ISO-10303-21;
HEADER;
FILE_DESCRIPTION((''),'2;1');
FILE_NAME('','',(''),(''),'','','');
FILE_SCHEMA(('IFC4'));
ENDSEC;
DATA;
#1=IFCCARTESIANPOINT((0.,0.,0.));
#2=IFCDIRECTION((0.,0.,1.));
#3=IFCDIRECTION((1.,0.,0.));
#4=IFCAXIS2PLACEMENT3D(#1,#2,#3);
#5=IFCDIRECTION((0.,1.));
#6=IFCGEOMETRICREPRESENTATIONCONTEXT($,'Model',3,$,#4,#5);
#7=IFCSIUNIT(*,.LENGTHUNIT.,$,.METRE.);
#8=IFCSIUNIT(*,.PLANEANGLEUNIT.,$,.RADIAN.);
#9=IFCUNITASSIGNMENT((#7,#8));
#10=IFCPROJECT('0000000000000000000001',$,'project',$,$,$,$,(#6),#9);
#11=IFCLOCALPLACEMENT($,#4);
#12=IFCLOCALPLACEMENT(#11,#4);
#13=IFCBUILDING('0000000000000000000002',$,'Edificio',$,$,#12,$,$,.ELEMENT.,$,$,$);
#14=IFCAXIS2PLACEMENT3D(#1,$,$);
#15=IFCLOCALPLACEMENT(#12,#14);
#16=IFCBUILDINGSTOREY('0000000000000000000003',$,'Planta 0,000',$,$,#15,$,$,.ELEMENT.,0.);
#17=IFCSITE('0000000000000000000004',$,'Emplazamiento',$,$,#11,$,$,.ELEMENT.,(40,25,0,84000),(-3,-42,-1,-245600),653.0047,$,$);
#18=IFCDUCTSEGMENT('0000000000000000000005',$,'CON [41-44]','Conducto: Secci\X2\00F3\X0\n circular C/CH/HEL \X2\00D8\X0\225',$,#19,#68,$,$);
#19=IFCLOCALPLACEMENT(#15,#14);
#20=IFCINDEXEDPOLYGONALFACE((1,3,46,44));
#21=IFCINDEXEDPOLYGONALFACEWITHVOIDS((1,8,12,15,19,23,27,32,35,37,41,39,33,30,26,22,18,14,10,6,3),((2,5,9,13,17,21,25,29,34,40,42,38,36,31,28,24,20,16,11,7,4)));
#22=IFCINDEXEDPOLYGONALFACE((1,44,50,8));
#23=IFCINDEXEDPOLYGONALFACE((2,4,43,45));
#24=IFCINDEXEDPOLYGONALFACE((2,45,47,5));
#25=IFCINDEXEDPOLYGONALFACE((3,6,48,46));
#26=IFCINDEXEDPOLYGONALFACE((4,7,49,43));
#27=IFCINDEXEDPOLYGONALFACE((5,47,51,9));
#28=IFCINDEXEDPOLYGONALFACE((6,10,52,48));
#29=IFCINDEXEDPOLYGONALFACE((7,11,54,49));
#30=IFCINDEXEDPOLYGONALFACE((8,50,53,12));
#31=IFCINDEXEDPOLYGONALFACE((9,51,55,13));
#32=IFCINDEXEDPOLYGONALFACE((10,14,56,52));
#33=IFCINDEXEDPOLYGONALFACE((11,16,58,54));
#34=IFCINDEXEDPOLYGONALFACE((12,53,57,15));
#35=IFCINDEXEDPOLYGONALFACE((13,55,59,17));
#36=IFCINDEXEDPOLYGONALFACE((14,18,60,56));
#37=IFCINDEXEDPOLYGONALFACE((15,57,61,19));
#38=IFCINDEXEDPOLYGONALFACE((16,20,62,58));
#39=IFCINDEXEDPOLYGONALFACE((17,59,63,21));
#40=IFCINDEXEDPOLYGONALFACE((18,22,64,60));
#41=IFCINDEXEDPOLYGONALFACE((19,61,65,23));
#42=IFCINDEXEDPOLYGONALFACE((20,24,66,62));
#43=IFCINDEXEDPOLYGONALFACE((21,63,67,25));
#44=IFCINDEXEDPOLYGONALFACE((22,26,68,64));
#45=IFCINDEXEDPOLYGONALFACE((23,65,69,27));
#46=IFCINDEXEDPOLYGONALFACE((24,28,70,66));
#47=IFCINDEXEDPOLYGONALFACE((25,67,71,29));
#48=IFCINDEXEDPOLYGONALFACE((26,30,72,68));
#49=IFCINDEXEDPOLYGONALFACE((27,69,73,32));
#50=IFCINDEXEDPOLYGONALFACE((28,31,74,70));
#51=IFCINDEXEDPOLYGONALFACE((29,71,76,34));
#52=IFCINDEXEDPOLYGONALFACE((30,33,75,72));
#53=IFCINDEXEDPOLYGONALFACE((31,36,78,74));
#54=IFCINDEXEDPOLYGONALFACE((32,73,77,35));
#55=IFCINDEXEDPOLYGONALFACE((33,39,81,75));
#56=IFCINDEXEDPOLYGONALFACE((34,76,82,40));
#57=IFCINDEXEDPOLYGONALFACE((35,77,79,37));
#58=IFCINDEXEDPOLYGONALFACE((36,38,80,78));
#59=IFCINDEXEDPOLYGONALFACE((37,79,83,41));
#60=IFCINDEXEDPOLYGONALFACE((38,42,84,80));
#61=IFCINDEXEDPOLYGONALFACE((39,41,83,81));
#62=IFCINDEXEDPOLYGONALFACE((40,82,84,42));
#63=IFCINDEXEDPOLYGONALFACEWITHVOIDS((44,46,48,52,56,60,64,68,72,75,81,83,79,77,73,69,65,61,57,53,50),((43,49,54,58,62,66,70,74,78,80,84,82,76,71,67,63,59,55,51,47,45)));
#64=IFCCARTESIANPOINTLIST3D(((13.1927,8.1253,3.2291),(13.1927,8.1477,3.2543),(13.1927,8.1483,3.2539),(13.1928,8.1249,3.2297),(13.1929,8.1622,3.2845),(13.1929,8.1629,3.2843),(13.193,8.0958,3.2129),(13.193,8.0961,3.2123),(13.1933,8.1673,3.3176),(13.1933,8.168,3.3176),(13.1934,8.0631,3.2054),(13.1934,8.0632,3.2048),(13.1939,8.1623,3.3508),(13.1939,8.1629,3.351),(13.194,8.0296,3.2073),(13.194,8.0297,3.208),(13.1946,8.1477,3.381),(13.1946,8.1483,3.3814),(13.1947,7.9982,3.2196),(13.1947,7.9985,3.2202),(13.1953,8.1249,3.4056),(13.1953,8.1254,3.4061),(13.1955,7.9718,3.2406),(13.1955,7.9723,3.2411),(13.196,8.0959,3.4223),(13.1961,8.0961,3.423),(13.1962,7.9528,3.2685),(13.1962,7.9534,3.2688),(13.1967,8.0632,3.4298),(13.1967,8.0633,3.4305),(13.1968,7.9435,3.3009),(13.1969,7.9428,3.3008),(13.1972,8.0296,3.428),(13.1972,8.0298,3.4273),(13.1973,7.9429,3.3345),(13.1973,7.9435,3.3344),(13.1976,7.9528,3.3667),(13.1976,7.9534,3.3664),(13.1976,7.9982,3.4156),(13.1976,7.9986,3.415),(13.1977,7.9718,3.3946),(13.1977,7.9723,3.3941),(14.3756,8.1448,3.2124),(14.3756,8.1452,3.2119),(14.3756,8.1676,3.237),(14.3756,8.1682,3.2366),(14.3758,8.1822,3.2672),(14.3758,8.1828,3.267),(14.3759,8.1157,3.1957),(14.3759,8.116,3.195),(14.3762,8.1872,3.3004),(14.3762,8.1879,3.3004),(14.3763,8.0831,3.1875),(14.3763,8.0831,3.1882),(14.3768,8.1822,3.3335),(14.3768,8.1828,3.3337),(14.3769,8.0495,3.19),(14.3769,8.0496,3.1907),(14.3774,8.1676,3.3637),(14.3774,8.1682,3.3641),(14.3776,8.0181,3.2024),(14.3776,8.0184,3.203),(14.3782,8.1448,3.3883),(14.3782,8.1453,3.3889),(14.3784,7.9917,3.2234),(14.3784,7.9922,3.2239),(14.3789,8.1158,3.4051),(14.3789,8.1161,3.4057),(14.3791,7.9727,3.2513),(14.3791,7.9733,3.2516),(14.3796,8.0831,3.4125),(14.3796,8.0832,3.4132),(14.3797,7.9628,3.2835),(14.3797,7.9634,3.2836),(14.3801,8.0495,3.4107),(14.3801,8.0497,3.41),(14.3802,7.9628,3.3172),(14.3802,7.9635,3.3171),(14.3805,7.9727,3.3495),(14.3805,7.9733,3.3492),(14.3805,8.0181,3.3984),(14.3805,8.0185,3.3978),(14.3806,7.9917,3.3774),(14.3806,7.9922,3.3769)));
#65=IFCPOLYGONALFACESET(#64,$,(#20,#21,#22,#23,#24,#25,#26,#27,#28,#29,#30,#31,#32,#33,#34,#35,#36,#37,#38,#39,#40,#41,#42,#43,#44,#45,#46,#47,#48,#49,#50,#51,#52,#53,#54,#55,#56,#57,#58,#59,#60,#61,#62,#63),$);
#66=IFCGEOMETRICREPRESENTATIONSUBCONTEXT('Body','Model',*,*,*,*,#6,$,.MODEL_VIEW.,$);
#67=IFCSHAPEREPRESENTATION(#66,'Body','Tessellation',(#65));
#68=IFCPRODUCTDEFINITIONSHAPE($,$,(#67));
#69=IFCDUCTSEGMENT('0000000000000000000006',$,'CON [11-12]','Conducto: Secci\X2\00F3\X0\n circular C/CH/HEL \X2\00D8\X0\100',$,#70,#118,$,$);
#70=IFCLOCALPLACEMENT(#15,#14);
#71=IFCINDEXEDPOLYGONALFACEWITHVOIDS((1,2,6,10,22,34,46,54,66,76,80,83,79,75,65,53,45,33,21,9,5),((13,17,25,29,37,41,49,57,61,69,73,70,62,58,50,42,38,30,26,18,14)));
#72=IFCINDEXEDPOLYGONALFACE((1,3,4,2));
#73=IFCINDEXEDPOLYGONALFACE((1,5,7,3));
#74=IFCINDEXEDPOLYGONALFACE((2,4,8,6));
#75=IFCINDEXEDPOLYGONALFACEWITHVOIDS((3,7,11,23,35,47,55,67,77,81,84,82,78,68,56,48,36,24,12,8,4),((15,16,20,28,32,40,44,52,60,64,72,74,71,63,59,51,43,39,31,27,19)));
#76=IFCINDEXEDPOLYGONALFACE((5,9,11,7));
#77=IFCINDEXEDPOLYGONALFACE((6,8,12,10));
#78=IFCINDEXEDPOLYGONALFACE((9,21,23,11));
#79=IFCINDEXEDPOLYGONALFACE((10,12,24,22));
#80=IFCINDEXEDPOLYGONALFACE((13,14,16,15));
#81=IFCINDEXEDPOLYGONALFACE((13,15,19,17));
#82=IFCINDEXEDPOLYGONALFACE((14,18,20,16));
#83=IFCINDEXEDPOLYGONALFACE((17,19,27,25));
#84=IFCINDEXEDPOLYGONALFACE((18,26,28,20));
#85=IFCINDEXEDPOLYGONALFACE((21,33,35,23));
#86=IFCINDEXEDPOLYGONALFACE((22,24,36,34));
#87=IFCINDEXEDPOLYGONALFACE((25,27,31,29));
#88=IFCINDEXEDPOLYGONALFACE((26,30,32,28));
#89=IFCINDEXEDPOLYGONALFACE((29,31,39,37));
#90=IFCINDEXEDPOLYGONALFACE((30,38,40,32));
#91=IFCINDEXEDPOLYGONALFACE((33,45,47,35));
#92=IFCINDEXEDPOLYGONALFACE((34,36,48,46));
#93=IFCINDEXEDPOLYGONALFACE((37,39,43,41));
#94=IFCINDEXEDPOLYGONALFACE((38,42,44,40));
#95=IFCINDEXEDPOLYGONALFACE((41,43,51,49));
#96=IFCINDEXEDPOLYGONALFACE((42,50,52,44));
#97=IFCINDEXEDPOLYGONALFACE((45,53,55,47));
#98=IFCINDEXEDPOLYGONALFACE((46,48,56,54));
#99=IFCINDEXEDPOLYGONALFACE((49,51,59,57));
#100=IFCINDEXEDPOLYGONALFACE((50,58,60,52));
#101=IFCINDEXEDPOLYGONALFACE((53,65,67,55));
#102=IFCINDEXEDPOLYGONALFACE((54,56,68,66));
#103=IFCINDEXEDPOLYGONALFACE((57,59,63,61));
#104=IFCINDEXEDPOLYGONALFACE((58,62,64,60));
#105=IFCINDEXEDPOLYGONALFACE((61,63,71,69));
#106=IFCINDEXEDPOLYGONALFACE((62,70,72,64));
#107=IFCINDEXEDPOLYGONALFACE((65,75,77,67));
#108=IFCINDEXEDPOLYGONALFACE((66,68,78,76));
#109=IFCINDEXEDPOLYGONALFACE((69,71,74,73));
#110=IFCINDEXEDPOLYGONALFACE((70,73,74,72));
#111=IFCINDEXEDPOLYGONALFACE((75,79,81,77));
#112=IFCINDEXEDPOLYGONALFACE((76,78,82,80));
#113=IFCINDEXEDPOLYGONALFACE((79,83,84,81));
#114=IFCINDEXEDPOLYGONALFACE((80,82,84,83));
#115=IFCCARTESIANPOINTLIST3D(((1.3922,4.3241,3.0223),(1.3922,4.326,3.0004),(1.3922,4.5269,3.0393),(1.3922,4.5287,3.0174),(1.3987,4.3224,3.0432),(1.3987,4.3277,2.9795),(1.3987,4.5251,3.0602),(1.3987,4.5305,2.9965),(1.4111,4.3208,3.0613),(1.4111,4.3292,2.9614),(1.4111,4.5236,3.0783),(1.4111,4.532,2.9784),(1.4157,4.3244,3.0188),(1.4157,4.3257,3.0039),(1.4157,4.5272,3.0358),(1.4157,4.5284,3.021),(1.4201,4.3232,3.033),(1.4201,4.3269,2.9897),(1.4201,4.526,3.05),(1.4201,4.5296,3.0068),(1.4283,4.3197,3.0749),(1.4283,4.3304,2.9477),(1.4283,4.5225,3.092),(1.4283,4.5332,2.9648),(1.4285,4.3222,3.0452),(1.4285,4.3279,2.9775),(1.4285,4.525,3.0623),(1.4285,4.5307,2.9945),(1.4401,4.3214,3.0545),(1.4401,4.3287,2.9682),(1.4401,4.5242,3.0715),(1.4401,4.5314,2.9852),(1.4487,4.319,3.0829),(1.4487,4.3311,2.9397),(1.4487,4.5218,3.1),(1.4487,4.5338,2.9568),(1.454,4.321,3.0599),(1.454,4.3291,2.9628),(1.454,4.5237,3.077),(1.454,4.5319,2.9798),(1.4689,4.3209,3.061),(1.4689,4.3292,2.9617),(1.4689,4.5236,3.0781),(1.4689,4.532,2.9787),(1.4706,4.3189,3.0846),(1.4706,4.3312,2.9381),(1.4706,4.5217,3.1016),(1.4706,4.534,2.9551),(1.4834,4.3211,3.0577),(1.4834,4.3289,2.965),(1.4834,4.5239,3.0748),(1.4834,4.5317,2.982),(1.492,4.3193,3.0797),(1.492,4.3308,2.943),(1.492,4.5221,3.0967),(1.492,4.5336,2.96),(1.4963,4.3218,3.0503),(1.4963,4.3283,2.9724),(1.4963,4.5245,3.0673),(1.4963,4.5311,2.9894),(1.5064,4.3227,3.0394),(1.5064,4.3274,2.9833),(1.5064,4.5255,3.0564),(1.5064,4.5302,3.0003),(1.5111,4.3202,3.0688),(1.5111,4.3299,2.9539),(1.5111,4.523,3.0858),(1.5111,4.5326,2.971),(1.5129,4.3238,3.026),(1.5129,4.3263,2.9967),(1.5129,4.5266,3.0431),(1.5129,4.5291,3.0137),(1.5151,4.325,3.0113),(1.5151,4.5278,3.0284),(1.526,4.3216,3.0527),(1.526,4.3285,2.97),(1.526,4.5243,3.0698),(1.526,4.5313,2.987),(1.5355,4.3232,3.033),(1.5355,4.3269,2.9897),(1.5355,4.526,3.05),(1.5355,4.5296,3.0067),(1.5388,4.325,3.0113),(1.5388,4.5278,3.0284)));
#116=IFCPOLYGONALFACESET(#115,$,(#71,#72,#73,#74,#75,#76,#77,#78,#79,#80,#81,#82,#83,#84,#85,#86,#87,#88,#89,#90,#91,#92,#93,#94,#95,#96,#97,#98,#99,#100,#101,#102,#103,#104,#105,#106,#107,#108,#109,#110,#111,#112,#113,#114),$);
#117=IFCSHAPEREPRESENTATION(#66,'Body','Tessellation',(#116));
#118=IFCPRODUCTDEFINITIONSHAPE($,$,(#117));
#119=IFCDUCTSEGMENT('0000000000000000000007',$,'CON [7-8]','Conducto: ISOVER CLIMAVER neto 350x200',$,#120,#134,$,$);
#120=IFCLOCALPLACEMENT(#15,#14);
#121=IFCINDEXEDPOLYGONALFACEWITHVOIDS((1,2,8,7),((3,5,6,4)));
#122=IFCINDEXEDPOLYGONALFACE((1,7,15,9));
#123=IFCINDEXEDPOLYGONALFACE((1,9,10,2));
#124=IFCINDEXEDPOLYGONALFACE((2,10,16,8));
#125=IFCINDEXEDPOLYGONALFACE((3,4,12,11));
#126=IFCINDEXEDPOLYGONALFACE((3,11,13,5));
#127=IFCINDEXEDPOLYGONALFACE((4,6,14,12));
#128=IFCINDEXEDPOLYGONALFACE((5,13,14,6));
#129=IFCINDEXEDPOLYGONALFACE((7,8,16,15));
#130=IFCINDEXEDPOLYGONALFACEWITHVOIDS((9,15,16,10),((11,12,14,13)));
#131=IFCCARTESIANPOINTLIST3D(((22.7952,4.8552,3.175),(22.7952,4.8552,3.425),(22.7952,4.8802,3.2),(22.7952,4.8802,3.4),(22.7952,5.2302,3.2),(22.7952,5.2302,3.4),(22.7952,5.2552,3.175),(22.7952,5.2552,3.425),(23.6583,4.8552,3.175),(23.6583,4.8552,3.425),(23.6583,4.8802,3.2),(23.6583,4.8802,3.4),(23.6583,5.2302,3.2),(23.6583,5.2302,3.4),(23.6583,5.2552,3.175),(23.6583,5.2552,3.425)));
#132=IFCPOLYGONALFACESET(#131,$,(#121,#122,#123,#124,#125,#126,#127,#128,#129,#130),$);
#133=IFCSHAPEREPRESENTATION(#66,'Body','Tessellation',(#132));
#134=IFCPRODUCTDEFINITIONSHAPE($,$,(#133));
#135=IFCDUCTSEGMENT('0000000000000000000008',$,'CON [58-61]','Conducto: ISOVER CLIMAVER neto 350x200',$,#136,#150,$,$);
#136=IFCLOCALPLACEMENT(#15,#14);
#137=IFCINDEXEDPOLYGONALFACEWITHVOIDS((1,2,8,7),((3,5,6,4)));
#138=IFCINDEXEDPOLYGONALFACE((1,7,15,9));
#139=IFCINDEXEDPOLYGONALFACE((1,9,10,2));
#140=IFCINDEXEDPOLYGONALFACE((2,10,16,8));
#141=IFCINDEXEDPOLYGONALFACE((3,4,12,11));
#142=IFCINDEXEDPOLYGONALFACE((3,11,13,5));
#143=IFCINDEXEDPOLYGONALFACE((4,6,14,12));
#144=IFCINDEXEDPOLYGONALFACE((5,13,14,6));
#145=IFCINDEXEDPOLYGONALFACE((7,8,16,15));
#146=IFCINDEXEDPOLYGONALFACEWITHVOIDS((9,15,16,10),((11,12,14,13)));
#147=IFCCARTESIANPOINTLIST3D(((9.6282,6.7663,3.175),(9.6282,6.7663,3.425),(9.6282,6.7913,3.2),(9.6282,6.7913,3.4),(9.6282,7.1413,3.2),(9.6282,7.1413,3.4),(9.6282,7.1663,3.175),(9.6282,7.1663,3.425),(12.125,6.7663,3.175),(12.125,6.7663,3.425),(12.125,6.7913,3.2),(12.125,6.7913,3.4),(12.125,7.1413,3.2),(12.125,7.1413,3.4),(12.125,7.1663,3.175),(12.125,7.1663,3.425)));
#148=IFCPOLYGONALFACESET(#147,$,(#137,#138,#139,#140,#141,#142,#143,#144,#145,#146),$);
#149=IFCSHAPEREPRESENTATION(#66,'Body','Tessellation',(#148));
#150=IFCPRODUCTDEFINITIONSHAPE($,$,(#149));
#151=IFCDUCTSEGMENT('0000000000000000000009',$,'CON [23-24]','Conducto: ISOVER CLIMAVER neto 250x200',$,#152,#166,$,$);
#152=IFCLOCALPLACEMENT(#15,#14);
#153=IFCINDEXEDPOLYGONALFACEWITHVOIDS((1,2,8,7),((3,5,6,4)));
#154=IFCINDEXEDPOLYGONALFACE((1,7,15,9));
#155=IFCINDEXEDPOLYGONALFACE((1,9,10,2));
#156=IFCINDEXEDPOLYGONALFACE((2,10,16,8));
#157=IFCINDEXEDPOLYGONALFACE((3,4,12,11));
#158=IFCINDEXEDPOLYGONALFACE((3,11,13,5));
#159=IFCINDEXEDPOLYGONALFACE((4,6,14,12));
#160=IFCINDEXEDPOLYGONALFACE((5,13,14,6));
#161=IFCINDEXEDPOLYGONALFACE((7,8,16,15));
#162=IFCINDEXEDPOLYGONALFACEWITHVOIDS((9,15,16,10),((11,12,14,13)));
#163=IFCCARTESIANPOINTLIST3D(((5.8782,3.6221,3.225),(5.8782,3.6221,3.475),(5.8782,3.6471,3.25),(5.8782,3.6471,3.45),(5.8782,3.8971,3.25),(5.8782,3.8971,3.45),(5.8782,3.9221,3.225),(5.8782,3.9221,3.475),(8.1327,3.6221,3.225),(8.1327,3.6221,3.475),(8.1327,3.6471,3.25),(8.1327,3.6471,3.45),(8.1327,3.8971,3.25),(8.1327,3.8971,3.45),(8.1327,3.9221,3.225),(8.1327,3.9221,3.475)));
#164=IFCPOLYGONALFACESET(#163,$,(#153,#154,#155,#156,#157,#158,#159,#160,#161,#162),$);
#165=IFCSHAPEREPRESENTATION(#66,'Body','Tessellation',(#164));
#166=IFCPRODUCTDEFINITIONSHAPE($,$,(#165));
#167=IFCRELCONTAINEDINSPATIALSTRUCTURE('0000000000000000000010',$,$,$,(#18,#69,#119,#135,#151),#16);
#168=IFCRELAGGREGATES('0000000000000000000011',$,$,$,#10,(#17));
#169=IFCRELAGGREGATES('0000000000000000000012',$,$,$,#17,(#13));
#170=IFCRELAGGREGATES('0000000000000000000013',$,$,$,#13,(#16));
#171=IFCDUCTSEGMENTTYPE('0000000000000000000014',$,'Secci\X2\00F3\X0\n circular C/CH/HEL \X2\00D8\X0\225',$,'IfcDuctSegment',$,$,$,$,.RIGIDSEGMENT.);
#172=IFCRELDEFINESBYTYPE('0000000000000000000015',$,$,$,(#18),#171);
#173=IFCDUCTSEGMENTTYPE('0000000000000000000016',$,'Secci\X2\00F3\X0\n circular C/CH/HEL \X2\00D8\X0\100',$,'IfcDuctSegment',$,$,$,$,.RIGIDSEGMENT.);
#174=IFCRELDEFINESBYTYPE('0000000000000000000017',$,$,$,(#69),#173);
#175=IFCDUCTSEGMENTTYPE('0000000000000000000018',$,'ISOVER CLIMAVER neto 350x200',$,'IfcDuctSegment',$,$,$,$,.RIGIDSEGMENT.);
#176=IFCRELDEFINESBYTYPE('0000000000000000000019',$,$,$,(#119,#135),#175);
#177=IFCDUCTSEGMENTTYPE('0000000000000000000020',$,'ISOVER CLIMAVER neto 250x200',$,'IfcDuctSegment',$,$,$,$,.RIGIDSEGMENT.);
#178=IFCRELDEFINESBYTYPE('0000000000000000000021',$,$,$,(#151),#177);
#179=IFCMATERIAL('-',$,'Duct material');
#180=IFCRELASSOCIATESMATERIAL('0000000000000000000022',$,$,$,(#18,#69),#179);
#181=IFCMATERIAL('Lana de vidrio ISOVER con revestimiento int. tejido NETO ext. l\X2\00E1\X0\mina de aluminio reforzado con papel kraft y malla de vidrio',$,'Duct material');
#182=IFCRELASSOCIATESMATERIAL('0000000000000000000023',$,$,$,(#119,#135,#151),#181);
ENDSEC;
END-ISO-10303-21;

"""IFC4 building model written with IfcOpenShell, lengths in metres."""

from ifc_helpers import new_model, si_unit, direction, frame, origin, origin_with_axes, origin_2d_with_axis, place, context, subcontext, project, spatial, hollow_rectangle, hollow_circle, extrude, material, type_object, element, save


model = new_model("IFC4")

# Units and contexts
model_context = context("Model", 3, world=origin_with_axes(), true_north=direction((0.0, 1.0)))
body_context = subcontext(model_context, "Body", "Model", "MODEL_VIEW")
ifc_project = project(units=[si_unit("LENGTHUNIT", "METRE"), si_unit("PLANEANGLEUNIT", "RADIAN")], contexts=[model_context])

# Site, building, storey
site_placement = place(None, origin_with_axes())
site = spatial("IfcSite", under=ifc_project, at=site_placement, Name="Emplazamiento", CompositionType="ELEMENT", RefLatitude=(40, 25, 0, 84000), RefLongitude=(-3, -42, -1, -245600), RefElevation=653.0047)
building_placement = place(site_placement, origin_with_axes())
building = spatial("IfcBuilding", under=site, at=building_placement, Name="Edificio", CompositionType="ELEMENT")
storey_placement = place(building_placement, origin())
storey = spatial("IfcBuildingStorey", under=building, at=storey_placement, Name="Planta 0,000", CompositionType="ELEMENT", Elevation=0.0)

# Shared definitions
ifc_material_1 = material(Name="-", Category="Duct material")

# Shared definitions
ifc_material_2 = material(Name="Lana de vidrio ISOVER con revestimiento int. tejido NETO ext. lámina de aluminio reforzado con papel kraft y malla de vidrio", Category="Duct material")

# Duct segments
duct_segment_type_1 = type_object("IfcDuctSegmentType", Name="Sección circular C/CH/HEL Ø225", ApplicableOccurrence="IfcDuctSegment", PredefinedType="RIGIDSEGMENT")
duct_segment_1_placement = place(storey_placement, origin_with_axes())
element("IfcDuctSegment", 1, at=duct_segment_1_placement, inside=storey, type_object=duct_segment_type_1, material=ifc_material_1, Name="CON [41-44]", Description="Conducto: Sección circular C/CH/HEL Ø225", context=body_context, shape_type="SweptSolid", body=[
    extrude(hollow_circle(Radius=0.1132, WallThickness=0.0007, at=origin_2d_with_axis()), frame((13.1952, 8.0548, 3.3176), z_axis=(0.999752, 0.016826, -0.014576), x_axis=(-0.016828, 0.999858, 0.0)), (0.0, 0.0, 1.0), 1.1832),
])
duct_segment_type_2 = type_object("IfcDuctSegmentType", Name="Sección circular C/CH/HEL Ø100", ApplicableOccurrence="IfcDuctSegment", PredefinedType="RIGIDSEGMENT")
duct_segment_2_placement = place(storey_placement, origin_with_axes())
element("IfcDuctSegment", 2, at=duct_segment_2_placement, inside=storey, type_object=duct_segment_type_2, material=ifc_material_1, Name="CON [11-12]", Description="Conducto: Sección circular C/CH/HEL Ø100", context=body_context, shape_type="SweptSolid", body=[
    extrude(hollow_circle(Radius=0.0737, WallThickness=0.0237, at=origin_2d_with_axis()), frame((1.4651, 4.5278, 3.0284), z_axis=(0.0, -0.99649, -0.083712), x_axis=(1.0, 0.0, 0.0)), (0.0, 0.0, 1.0), 0.2035),
])

# Duct segments
duct_segment_type_3 = type_object("IfcDuctSegmentType", Name="ISOVER CLIMAVER neto 350x200", ApplicableOccurrence="IfcDuctSegment", PredefinedType="RIGIDSEGMENT")
duct_segment_3_placement = place(storey_placement, origin_with_axes())
element("IfcDuctSegment", 3, at=duct_segment_3_placement, inside=storey, type_object=duct_segment_type_3, material=ifc_material_2, Name="CON [7-8]", Description="Conducto: ISOVER CLIMAVER neto 350x200", context=body_context, shape_type="SweptSolid", body=[
    extrude(hollow_rectangle(XDim=0.4, YDim=0.25, WallThickness=0.025, at=origin_2d_with_axis()), frame((22.7952, 5.0552, 3.3), z_axis=(1.0, 0.0, 0.0), x_axis=(0.0, 1.0, 0.0)), (0.0, 0.0, 1.0), 0.8631),
])
duct_segment_4_placement = place(storey_placement, origin_with_axes())
element("IfcDuctSegment", 4, at=duct_segment_4_placement, inside=storey, type_object=duct_segment_type_3, material=ifc_material_2, Name="CON [58-61]", Description="Conducto: ISOVER CLIMAVER neto 350x200", context=body_context, shape_type="SweptSolid", body=[
    extrude(hollow_rectangle(XDim=0.4, YDim=0.25, WallThickness=0.025, at=origin_2d_with_axis()), frame((12.125, 6.9663, 3.3), z_axis=(-1.0, 0.0, 0.0), x_axis=(0.0, -1.0, 0.0)), (0.0, 0.0, 1.0), 2.4968),
])
duct_segment_type_4 = type_object("IfcDuctSegmentType", Name="ISOVER CLIMAVER neto 250x200", ApplicableOccurrence="IfcDuctSegment", PredefinedType="RIGIDSEGMENT")
duct_segment_5_placement = place(storey_placement, origin_with_axes())
element("IfcDuctSegment", 5, at=duct_segment_5_placement, inside=storey, type_object=duct_segment_type_4, material=ifc_material_2, Name="CON [23-24]", Description="Conducto: ISOVER CLIMAVER neto 250x200", context=body_context, shape_type="SweptSolid", body=[
    extrude(hollow_rectangle(XDim=0.3, YDim=0.25, WallThickness=0.025, at=origin_2d_with_axis()), frame((8.1327, 3.7721, 3.35), z_axis=(-1.0, 0.0, 0.0), x_axis=(0.0, -1.0, 0.0)), (0.0, 0.0, 1.0), 2.2545),
])

save(model, "model.ifc")
